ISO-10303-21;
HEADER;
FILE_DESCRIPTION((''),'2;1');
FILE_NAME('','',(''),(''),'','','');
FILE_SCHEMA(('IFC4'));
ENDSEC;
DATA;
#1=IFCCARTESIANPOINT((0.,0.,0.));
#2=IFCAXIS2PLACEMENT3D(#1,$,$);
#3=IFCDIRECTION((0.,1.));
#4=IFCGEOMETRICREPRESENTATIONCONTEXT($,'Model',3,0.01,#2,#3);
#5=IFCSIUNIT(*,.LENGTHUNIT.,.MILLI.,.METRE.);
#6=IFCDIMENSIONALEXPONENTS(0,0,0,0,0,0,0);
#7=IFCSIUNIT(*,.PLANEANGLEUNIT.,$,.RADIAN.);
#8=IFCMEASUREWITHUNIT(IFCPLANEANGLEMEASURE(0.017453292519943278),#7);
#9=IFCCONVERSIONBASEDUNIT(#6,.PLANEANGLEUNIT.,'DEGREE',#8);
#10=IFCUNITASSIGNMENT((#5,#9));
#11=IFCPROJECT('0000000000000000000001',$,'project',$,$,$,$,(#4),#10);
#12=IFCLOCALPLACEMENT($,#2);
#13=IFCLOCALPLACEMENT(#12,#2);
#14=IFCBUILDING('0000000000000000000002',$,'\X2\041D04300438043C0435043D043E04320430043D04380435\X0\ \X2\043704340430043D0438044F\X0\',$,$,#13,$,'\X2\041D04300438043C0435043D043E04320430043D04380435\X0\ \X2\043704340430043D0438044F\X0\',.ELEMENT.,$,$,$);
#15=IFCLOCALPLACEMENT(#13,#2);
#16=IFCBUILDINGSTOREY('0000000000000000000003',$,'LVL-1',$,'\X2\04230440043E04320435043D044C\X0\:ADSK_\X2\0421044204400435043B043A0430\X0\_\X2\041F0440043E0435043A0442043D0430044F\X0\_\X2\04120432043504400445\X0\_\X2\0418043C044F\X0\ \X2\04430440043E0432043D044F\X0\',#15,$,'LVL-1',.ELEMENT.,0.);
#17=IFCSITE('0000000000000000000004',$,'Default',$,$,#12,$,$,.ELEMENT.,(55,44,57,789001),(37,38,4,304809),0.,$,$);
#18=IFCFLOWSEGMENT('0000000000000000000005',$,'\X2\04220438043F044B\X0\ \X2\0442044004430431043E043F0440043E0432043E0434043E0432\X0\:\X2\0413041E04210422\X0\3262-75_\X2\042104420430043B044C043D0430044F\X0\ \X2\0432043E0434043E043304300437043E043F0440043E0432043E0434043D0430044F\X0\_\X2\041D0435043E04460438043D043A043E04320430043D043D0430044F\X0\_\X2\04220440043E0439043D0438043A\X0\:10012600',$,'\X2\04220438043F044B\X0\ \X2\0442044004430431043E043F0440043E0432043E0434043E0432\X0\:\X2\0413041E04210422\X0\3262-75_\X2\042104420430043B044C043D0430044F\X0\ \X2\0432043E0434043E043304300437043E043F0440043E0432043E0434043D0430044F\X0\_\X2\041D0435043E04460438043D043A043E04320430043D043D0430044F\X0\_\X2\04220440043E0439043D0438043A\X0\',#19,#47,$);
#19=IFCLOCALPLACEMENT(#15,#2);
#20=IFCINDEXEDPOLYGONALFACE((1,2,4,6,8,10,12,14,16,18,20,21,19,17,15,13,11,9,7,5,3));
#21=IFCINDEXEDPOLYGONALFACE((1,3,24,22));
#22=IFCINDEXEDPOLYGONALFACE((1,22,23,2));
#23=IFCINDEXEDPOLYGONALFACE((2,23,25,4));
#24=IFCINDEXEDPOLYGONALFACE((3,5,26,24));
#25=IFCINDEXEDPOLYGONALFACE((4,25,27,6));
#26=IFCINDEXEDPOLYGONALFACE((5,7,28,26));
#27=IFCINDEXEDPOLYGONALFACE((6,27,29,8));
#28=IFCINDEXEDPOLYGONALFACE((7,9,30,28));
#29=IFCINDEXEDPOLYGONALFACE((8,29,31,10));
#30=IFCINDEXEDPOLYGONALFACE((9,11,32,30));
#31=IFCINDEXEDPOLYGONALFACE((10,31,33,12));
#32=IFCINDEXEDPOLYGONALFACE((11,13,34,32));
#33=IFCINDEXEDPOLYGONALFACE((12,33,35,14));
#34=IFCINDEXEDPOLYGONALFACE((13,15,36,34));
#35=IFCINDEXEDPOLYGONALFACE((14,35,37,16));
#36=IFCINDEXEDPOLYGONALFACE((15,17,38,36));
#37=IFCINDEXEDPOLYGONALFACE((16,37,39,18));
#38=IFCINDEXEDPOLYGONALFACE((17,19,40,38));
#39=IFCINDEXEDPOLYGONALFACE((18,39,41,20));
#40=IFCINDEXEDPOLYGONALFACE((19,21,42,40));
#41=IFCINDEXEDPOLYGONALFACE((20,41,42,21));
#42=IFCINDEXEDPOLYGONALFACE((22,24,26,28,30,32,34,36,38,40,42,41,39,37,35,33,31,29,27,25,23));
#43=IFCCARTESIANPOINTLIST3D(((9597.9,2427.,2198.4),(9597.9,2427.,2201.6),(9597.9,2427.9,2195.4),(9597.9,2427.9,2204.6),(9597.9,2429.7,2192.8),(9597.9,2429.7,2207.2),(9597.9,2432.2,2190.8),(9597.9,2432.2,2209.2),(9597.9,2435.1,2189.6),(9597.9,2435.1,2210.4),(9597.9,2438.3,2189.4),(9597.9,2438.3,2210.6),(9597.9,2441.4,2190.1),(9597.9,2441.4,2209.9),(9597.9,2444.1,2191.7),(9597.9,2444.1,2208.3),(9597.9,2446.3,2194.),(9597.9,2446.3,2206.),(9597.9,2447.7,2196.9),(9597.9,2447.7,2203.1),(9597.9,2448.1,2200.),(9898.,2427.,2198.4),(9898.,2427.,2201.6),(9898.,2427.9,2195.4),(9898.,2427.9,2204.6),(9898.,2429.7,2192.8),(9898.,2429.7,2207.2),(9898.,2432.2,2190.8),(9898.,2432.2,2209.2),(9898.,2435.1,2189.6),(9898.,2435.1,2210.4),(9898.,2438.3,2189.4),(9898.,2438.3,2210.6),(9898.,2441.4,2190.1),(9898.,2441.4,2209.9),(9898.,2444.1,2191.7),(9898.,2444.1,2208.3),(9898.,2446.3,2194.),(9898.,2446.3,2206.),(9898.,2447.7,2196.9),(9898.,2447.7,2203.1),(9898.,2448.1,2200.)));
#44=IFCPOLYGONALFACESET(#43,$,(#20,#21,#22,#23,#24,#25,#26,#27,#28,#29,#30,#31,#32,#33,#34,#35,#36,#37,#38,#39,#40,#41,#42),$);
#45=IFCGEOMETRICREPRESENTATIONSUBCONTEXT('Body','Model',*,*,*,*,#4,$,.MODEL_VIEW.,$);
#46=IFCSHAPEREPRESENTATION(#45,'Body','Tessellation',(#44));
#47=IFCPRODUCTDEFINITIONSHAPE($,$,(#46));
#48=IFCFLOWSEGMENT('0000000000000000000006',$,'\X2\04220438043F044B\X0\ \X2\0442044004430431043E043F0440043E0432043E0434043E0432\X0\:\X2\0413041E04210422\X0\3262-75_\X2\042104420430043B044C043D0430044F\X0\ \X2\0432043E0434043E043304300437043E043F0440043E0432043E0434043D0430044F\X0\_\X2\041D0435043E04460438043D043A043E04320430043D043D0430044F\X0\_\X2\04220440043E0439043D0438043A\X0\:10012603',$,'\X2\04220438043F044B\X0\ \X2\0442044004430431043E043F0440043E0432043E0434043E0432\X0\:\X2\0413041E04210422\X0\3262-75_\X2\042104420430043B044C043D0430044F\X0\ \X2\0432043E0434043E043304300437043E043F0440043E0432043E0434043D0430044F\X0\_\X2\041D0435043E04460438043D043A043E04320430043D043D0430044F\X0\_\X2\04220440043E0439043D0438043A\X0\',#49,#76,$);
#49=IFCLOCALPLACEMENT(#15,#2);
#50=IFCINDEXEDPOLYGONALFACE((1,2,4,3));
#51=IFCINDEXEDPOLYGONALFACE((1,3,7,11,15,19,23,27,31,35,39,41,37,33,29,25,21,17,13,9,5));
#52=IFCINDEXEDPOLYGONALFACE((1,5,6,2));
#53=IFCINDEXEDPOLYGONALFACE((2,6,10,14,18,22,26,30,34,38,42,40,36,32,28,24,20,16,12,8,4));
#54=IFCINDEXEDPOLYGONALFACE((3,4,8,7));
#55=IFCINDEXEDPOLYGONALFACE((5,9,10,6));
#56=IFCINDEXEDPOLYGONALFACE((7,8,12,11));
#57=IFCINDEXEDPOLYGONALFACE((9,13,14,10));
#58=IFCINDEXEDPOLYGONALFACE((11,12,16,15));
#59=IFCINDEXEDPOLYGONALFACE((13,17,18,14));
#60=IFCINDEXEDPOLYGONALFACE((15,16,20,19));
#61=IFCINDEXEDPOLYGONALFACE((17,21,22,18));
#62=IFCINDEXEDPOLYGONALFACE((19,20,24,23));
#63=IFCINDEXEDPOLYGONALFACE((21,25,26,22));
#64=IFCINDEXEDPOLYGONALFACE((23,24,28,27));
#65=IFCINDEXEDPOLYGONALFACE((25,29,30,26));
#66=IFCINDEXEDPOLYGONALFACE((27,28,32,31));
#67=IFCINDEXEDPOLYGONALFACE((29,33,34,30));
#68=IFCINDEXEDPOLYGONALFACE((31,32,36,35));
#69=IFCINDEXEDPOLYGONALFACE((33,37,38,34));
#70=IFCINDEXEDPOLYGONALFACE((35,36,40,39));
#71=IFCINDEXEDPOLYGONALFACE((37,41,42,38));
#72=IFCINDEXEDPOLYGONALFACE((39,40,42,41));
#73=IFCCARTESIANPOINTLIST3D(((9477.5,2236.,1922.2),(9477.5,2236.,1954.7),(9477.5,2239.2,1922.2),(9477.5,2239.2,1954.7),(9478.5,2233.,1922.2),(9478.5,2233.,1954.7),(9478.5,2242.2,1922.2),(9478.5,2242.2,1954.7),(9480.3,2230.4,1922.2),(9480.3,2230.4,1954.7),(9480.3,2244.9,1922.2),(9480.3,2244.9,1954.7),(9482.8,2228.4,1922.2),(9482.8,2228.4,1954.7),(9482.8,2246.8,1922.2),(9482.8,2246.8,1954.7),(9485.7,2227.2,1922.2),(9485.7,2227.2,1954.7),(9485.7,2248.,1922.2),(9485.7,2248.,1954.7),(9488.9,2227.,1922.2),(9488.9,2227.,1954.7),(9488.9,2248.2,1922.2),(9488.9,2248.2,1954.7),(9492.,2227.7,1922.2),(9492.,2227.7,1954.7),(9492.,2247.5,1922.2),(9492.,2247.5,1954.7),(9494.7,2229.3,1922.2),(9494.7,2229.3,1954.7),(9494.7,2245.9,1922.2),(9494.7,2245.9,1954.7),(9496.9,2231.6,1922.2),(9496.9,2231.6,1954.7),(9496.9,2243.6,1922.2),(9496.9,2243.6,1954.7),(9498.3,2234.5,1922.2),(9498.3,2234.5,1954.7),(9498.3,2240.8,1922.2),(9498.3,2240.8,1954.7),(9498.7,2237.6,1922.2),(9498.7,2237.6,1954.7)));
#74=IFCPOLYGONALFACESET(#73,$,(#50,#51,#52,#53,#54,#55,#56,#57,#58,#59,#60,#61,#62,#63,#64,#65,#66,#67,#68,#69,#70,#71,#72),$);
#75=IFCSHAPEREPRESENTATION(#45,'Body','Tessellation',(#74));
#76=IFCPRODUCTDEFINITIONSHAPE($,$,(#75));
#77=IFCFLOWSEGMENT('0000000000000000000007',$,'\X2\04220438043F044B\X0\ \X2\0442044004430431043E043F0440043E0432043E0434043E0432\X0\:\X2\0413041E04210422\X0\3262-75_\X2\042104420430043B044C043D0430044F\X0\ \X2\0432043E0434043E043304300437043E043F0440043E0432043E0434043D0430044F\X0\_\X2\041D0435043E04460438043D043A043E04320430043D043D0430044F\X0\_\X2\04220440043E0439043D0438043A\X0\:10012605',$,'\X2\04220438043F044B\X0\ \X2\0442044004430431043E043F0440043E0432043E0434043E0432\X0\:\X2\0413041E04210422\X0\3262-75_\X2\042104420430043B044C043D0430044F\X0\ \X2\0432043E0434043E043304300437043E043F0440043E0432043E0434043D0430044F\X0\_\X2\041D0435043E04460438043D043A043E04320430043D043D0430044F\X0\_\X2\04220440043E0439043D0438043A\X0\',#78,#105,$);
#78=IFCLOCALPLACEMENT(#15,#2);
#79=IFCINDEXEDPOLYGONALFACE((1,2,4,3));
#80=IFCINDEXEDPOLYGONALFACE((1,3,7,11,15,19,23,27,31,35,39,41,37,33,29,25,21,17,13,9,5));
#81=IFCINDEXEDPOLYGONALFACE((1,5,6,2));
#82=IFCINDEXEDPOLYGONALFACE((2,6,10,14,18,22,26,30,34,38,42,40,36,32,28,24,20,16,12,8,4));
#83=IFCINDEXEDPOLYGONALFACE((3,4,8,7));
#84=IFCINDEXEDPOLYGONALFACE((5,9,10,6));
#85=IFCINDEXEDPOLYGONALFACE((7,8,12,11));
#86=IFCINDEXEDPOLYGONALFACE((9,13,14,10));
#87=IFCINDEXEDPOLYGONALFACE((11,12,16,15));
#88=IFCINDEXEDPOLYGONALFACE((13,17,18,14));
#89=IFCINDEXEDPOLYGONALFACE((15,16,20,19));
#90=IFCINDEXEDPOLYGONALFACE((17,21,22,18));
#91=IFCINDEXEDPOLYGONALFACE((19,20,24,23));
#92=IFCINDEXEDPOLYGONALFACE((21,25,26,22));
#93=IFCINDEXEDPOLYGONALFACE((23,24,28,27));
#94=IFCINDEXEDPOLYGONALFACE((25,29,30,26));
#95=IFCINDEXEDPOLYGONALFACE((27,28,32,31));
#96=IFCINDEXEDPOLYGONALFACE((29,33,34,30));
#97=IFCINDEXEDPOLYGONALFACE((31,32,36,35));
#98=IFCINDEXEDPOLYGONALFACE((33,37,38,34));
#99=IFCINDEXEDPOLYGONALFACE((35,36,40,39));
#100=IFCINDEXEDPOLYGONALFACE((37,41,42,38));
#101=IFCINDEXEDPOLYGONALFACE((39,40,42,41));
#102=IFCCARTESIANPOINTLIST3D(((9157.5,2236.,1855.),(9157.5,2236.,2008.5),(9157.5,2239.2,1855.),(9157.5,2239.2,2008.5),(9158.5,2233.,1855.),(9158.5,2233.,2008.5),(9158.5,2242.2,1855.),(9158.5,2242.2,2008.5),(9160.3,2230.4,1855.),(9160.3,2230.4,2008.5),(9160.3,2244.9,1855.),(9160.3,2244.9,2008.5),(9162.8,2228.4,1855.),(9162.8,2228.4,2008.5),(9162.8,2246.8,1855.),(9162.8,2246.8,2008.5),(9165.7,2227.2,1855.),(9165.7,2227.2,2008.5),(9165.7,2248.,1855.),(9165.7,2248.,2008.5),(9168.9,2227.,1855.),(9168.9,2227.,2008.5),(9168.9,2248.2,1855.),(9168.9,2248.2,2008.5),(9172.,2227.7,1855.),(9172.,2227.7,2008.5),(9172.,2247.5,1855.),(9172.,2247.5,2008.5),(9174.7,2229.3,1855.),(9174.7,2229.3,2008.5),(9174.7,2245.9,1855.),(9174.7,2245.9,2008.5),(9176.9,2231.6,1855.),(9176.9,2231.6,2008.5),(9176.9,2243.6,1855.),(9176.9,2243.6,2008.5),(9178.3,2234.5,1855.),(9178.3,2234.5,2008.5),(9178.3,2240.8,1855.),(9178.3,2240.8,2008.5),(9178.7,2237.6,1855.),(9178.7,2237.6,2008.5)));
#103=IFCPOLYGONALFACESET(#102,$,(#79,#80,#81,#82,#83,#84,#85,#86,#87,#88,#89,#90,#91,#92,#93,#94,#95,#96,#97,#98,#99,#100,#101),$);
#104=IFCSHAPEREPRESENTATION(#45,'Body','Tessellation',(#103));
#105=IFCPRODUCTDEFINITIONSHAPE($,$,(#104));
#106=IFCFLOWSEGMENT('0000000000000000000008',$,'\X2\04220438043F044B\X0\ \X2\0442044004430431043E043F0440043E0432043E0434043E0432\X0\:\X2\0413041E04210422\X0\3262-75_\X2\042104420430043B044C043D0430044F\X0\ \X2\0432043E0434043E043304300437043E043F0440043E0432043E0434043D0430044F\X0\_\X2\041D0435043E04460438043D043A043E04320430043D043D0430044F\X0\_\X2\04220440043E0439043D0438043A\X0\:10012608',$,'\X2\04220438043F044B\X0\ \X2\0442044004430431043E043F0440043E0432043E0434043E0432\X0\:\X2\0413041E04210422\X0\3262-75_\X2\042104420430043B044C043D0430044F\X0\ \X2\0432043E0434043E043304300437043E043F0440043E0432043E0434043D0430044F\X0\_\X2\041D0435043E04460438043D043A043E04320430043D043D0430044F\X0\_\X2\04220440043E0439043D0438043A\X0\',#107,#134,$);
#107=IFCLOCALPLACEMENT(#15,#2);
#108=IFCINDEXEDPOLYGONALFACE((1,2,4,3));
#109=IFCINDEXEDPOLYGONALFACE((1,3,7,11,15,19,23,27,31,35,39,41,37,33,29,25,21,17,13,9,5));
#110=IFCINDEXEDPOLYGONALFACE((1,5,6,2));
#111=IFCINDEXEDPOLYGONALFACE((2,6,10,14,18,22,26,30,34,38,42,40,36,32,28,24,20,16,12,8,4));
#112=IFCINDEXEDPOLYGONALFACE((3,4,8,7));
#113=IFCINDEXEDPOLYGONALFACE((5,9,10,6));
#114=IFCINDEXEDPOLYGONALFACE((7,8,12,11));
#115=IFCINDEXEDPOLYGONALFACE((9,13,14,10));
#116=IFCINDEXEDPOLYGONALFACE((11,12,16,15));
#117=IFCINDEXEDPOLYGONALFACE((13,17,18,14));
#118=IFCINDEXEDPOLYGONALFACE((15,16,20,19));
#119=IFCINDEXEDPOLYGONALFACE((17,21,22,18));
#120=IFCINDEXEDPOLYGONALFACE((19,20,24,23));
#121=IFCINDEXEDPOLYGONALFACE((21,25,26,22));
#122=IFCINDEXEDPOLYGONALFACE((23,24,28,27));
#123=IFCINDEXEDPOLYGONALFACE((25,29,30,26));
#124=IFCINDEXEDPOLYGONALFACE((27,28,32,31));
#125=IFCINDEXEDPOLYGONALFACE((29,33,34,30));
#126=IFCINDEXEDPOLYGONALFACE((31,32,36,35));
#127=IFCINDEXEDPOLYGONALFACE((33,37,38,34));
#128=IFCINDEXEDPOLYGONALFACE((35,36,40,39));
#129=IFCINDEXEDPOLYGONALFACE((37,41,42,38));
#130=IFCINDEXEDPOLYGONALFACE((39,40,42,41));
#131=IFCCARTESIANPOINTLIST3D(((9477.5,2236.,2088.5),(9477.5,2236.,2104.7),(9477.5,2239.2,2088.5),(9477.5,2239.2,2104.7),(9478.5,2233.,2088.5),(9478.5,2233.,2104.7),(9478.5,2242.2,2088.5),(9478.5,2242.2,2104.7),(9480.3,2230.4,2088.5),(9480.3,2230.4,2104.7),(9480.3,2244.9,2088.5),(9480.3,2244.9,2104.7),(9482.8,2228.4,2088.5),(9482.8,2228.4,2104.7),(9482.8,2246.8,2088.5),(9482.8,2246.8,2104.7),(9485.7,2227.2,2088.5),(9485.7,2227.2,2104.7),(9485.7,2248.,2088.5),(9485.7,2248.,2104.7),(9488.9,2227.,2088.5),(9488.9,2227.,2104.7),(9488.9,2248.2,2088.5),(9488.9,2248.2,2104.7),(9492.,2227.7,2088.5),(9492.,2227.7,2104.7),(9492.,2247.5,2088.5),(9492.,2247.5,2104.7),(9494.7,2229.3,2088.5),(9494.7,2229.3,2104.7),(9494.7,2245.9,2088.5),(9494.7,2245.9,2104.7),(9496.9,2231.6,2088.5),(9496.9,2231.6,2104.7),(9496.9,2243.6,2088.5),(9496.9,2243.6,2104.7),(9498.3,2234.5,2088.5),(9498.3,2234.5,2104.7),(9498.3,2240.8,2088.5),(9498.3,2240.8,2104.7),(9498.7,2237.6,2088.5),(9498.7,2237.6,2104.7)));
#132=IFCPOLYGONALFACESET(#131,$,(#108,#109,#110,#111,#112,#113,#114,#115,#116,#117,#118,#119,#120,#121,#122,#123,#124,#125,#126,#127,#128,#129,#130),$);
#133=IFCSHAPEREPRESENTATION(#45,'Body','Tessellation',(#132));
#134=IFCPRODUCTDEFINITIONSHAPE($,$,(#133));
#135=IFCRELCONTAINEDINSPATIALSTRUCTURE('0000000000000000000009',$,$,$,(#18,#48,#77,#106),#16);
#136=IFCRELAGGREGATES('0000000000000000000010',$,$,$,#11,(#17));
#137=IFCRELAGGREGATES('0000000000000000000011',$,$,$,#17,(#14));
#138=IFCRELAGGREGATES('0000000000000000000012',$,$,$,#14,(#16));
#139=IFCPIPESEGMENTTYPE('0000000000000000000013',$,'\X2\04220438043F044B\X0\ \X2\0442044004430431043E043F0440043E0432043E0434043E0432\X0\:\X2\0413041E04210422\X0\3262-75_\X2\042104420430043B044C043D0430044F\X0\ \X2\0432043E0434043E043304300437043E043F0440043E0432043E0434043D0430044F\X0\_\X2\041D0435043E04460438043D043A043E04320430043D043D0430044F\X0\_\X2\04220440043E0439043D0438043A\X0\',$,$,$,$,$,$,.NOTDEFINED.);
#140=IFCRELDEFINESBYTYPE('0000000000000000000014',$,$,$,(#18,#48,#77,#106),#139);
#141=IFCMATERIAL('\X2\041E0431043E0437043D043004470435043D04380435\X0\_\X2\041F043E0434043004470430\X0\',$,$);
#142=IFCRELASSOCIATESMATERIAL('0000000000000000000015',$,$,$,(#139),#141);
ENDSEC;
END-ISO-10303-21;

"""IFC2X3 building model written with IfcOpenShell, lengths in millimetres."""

from ifc_helpers import new_model, entity, si_unit, converted_unit, direction, frame, frame_2d, origin, origin_2d_with_axis, place, context, subcontext, project, spatial, circle, extrude, material, type_object, element, save


model = new_model("IFC2X3")

# Units and contexts
model_context = context("Model", 3, precision=0.01, world=origin(), true_north=direction((0.0, 1.0)))
body_context = subcontext(model_context, "Body", "Model", "MODEL_VIEW")
ifc_project = project(units=[si_unit("LENGTHUNIT", "METRE", prefix="MILLI"), converted_unit("PLANEANGLEUNIT", "DEGREE", entity("IfcPlaneAngleMeasure", 0.017453292519943278), si_unit("PLANEANGLEUNIT", "RADIAN"), dimensions=[0, 0, 0, 0, 0, 0, 0])], contexts=[model_context])

# Site, building, storey
site_placement = place(None, origin())
site = spatial("IfcSite", under=ifc_project, at=site_placement, Name="Default", CompositionType="ELEMENT", RefLatitude=(55, 44, 57, 789001), RefLongitude=(37, 38, 4, 304809), RefElevation=0.0)
building_placement = place(site_placement, origin())
building = spatial("IfcBuilding", under=site, at=building_placement, Name="Наименование здания", LongName="Наименование здания", CompositionType="ELEMENT")
storey_placement = place(building_placement, origin())
storey = spatial("IfcBuildingStorey", under=building, at=storey_placement, Name="LVL-1", ObjectType="Уровень:ADSK_Стрелка_Проектная_Вверх_Имя уровня", LongName="LVL-1", CompositionType="ELEMENT", Elevation=0.0)

# Flow segments
ifc_material_1 = material(Name="Обозначение_Подача")
pipe_segment_type_1 = type_object("IfcPipeSegmentType", Name="Типы трубопроводов:ГОСТ3262-75_Стальная водогазопроводная_Неоцинкованная_Тройник", PredefinedType="NOTDEFINED", material=ifc_material_1)
flow_segment_1_placement = place(storey_placement, origin())
element("IfcFlowSegment", 1, at=flow_segment_1_placement, inside=storey, type_object=pipe_segment_type_1, Name="Типы трубопроводов:ГОСТ3262-75_Стальная водогазопроводная_Неоцинкованная_Тройник:10012600", ObjectType="Типы трубопроводов:ГОСТ3262-75_Стальная водогазопроводная_Неоцинкованная_Тройник", context=body_context, shape_type="SweptSolid", body=[
    extrude(circle(Radius=10.7, at=frame_2d((0.0, 0.0), x_axis=(1.0, 0.0))), frame((9597.9, 2437.5, 2200.0), z_axis=(1.0, 0.0, 0.0), x_axis=(0.0, 1.0, 0.0)), (0.0, 0.0, 1.0), 300.0),
])
flow_segment_2_placement = place(storey_placement, origin())
element("IfcFlowSegment", 2, at=flow_segment_2_placement, inside=storey, type_object=pipe_segment_type_1, Name="Типы трубопроводов:ГОСТ3262-75_Стальная водогазопроводная_Неоцинкованная_Тройник:10012603", ObjectType="Типы трубопроводов:ГОСТ3262-75_Стальная водогазопроводная_Неоцинкованная_Тройник", context=body_context, shape_type="SweptSolid", body=[
    extrude(circle(Radius=10.7, at=frame_2d((0.0, 0.0), x_axis=(1.0, 0.0))), frame((9488.1, 2237.6, 1922.2)), (0.0, 0.0, 1.0), 32.5),
])
flow_segment_3_placement = place(storey_placement, origin())
element("IfcFlowSegment", 3, at=flow_segment_3_placement, inside=storey, type_object=pipe_segment_type_1, Name="Типы трубопроводов:ГОСТ3262-75_Стальная водогазопроводная_Неоцинкованная_Тройник:10012605", ObjectType="Типы трубопроводов:ГОСТ3262-75_Стальная водогазопроводная_Неоцинкованная_Тройник", context=body_context, shape_type="SweptSolid", body=[
    extrude(circle(Radius=10.7, at=origin_2d_with_axis()), frame((9168.1, 2237.6, 1855.0)), (0.0, 0.0, 1.0), 153.5),
])
flow_segment_4_placement = place(storey_placement, origin())
element("IfcFlowSegment", 4, at=flow_segment_4_placement, inside=storey, type_object=pipe_segment_type_1, Name="Типы трубопроводов:ГОСТ3262-75_Стальная водогазопроводная_Неоцинкованная_Тройник:10012608", ObjectType="Типы трубопроводов:ГОСТ3262-75_Стальная водогазопроводная_Неоцинкованная_Тройник", context=body_context, shape_type="SweptSolid", body=[
    extrude(circle(Radius=10.7, at=frame_2d((0.0, 0.0), x_axis=(1.0, 0.0))), frame((9488.1, 2237.6, 2088.5)), (0.0, 0.0, 1.0), 16.2),
])

save(model, "model.ifc")
